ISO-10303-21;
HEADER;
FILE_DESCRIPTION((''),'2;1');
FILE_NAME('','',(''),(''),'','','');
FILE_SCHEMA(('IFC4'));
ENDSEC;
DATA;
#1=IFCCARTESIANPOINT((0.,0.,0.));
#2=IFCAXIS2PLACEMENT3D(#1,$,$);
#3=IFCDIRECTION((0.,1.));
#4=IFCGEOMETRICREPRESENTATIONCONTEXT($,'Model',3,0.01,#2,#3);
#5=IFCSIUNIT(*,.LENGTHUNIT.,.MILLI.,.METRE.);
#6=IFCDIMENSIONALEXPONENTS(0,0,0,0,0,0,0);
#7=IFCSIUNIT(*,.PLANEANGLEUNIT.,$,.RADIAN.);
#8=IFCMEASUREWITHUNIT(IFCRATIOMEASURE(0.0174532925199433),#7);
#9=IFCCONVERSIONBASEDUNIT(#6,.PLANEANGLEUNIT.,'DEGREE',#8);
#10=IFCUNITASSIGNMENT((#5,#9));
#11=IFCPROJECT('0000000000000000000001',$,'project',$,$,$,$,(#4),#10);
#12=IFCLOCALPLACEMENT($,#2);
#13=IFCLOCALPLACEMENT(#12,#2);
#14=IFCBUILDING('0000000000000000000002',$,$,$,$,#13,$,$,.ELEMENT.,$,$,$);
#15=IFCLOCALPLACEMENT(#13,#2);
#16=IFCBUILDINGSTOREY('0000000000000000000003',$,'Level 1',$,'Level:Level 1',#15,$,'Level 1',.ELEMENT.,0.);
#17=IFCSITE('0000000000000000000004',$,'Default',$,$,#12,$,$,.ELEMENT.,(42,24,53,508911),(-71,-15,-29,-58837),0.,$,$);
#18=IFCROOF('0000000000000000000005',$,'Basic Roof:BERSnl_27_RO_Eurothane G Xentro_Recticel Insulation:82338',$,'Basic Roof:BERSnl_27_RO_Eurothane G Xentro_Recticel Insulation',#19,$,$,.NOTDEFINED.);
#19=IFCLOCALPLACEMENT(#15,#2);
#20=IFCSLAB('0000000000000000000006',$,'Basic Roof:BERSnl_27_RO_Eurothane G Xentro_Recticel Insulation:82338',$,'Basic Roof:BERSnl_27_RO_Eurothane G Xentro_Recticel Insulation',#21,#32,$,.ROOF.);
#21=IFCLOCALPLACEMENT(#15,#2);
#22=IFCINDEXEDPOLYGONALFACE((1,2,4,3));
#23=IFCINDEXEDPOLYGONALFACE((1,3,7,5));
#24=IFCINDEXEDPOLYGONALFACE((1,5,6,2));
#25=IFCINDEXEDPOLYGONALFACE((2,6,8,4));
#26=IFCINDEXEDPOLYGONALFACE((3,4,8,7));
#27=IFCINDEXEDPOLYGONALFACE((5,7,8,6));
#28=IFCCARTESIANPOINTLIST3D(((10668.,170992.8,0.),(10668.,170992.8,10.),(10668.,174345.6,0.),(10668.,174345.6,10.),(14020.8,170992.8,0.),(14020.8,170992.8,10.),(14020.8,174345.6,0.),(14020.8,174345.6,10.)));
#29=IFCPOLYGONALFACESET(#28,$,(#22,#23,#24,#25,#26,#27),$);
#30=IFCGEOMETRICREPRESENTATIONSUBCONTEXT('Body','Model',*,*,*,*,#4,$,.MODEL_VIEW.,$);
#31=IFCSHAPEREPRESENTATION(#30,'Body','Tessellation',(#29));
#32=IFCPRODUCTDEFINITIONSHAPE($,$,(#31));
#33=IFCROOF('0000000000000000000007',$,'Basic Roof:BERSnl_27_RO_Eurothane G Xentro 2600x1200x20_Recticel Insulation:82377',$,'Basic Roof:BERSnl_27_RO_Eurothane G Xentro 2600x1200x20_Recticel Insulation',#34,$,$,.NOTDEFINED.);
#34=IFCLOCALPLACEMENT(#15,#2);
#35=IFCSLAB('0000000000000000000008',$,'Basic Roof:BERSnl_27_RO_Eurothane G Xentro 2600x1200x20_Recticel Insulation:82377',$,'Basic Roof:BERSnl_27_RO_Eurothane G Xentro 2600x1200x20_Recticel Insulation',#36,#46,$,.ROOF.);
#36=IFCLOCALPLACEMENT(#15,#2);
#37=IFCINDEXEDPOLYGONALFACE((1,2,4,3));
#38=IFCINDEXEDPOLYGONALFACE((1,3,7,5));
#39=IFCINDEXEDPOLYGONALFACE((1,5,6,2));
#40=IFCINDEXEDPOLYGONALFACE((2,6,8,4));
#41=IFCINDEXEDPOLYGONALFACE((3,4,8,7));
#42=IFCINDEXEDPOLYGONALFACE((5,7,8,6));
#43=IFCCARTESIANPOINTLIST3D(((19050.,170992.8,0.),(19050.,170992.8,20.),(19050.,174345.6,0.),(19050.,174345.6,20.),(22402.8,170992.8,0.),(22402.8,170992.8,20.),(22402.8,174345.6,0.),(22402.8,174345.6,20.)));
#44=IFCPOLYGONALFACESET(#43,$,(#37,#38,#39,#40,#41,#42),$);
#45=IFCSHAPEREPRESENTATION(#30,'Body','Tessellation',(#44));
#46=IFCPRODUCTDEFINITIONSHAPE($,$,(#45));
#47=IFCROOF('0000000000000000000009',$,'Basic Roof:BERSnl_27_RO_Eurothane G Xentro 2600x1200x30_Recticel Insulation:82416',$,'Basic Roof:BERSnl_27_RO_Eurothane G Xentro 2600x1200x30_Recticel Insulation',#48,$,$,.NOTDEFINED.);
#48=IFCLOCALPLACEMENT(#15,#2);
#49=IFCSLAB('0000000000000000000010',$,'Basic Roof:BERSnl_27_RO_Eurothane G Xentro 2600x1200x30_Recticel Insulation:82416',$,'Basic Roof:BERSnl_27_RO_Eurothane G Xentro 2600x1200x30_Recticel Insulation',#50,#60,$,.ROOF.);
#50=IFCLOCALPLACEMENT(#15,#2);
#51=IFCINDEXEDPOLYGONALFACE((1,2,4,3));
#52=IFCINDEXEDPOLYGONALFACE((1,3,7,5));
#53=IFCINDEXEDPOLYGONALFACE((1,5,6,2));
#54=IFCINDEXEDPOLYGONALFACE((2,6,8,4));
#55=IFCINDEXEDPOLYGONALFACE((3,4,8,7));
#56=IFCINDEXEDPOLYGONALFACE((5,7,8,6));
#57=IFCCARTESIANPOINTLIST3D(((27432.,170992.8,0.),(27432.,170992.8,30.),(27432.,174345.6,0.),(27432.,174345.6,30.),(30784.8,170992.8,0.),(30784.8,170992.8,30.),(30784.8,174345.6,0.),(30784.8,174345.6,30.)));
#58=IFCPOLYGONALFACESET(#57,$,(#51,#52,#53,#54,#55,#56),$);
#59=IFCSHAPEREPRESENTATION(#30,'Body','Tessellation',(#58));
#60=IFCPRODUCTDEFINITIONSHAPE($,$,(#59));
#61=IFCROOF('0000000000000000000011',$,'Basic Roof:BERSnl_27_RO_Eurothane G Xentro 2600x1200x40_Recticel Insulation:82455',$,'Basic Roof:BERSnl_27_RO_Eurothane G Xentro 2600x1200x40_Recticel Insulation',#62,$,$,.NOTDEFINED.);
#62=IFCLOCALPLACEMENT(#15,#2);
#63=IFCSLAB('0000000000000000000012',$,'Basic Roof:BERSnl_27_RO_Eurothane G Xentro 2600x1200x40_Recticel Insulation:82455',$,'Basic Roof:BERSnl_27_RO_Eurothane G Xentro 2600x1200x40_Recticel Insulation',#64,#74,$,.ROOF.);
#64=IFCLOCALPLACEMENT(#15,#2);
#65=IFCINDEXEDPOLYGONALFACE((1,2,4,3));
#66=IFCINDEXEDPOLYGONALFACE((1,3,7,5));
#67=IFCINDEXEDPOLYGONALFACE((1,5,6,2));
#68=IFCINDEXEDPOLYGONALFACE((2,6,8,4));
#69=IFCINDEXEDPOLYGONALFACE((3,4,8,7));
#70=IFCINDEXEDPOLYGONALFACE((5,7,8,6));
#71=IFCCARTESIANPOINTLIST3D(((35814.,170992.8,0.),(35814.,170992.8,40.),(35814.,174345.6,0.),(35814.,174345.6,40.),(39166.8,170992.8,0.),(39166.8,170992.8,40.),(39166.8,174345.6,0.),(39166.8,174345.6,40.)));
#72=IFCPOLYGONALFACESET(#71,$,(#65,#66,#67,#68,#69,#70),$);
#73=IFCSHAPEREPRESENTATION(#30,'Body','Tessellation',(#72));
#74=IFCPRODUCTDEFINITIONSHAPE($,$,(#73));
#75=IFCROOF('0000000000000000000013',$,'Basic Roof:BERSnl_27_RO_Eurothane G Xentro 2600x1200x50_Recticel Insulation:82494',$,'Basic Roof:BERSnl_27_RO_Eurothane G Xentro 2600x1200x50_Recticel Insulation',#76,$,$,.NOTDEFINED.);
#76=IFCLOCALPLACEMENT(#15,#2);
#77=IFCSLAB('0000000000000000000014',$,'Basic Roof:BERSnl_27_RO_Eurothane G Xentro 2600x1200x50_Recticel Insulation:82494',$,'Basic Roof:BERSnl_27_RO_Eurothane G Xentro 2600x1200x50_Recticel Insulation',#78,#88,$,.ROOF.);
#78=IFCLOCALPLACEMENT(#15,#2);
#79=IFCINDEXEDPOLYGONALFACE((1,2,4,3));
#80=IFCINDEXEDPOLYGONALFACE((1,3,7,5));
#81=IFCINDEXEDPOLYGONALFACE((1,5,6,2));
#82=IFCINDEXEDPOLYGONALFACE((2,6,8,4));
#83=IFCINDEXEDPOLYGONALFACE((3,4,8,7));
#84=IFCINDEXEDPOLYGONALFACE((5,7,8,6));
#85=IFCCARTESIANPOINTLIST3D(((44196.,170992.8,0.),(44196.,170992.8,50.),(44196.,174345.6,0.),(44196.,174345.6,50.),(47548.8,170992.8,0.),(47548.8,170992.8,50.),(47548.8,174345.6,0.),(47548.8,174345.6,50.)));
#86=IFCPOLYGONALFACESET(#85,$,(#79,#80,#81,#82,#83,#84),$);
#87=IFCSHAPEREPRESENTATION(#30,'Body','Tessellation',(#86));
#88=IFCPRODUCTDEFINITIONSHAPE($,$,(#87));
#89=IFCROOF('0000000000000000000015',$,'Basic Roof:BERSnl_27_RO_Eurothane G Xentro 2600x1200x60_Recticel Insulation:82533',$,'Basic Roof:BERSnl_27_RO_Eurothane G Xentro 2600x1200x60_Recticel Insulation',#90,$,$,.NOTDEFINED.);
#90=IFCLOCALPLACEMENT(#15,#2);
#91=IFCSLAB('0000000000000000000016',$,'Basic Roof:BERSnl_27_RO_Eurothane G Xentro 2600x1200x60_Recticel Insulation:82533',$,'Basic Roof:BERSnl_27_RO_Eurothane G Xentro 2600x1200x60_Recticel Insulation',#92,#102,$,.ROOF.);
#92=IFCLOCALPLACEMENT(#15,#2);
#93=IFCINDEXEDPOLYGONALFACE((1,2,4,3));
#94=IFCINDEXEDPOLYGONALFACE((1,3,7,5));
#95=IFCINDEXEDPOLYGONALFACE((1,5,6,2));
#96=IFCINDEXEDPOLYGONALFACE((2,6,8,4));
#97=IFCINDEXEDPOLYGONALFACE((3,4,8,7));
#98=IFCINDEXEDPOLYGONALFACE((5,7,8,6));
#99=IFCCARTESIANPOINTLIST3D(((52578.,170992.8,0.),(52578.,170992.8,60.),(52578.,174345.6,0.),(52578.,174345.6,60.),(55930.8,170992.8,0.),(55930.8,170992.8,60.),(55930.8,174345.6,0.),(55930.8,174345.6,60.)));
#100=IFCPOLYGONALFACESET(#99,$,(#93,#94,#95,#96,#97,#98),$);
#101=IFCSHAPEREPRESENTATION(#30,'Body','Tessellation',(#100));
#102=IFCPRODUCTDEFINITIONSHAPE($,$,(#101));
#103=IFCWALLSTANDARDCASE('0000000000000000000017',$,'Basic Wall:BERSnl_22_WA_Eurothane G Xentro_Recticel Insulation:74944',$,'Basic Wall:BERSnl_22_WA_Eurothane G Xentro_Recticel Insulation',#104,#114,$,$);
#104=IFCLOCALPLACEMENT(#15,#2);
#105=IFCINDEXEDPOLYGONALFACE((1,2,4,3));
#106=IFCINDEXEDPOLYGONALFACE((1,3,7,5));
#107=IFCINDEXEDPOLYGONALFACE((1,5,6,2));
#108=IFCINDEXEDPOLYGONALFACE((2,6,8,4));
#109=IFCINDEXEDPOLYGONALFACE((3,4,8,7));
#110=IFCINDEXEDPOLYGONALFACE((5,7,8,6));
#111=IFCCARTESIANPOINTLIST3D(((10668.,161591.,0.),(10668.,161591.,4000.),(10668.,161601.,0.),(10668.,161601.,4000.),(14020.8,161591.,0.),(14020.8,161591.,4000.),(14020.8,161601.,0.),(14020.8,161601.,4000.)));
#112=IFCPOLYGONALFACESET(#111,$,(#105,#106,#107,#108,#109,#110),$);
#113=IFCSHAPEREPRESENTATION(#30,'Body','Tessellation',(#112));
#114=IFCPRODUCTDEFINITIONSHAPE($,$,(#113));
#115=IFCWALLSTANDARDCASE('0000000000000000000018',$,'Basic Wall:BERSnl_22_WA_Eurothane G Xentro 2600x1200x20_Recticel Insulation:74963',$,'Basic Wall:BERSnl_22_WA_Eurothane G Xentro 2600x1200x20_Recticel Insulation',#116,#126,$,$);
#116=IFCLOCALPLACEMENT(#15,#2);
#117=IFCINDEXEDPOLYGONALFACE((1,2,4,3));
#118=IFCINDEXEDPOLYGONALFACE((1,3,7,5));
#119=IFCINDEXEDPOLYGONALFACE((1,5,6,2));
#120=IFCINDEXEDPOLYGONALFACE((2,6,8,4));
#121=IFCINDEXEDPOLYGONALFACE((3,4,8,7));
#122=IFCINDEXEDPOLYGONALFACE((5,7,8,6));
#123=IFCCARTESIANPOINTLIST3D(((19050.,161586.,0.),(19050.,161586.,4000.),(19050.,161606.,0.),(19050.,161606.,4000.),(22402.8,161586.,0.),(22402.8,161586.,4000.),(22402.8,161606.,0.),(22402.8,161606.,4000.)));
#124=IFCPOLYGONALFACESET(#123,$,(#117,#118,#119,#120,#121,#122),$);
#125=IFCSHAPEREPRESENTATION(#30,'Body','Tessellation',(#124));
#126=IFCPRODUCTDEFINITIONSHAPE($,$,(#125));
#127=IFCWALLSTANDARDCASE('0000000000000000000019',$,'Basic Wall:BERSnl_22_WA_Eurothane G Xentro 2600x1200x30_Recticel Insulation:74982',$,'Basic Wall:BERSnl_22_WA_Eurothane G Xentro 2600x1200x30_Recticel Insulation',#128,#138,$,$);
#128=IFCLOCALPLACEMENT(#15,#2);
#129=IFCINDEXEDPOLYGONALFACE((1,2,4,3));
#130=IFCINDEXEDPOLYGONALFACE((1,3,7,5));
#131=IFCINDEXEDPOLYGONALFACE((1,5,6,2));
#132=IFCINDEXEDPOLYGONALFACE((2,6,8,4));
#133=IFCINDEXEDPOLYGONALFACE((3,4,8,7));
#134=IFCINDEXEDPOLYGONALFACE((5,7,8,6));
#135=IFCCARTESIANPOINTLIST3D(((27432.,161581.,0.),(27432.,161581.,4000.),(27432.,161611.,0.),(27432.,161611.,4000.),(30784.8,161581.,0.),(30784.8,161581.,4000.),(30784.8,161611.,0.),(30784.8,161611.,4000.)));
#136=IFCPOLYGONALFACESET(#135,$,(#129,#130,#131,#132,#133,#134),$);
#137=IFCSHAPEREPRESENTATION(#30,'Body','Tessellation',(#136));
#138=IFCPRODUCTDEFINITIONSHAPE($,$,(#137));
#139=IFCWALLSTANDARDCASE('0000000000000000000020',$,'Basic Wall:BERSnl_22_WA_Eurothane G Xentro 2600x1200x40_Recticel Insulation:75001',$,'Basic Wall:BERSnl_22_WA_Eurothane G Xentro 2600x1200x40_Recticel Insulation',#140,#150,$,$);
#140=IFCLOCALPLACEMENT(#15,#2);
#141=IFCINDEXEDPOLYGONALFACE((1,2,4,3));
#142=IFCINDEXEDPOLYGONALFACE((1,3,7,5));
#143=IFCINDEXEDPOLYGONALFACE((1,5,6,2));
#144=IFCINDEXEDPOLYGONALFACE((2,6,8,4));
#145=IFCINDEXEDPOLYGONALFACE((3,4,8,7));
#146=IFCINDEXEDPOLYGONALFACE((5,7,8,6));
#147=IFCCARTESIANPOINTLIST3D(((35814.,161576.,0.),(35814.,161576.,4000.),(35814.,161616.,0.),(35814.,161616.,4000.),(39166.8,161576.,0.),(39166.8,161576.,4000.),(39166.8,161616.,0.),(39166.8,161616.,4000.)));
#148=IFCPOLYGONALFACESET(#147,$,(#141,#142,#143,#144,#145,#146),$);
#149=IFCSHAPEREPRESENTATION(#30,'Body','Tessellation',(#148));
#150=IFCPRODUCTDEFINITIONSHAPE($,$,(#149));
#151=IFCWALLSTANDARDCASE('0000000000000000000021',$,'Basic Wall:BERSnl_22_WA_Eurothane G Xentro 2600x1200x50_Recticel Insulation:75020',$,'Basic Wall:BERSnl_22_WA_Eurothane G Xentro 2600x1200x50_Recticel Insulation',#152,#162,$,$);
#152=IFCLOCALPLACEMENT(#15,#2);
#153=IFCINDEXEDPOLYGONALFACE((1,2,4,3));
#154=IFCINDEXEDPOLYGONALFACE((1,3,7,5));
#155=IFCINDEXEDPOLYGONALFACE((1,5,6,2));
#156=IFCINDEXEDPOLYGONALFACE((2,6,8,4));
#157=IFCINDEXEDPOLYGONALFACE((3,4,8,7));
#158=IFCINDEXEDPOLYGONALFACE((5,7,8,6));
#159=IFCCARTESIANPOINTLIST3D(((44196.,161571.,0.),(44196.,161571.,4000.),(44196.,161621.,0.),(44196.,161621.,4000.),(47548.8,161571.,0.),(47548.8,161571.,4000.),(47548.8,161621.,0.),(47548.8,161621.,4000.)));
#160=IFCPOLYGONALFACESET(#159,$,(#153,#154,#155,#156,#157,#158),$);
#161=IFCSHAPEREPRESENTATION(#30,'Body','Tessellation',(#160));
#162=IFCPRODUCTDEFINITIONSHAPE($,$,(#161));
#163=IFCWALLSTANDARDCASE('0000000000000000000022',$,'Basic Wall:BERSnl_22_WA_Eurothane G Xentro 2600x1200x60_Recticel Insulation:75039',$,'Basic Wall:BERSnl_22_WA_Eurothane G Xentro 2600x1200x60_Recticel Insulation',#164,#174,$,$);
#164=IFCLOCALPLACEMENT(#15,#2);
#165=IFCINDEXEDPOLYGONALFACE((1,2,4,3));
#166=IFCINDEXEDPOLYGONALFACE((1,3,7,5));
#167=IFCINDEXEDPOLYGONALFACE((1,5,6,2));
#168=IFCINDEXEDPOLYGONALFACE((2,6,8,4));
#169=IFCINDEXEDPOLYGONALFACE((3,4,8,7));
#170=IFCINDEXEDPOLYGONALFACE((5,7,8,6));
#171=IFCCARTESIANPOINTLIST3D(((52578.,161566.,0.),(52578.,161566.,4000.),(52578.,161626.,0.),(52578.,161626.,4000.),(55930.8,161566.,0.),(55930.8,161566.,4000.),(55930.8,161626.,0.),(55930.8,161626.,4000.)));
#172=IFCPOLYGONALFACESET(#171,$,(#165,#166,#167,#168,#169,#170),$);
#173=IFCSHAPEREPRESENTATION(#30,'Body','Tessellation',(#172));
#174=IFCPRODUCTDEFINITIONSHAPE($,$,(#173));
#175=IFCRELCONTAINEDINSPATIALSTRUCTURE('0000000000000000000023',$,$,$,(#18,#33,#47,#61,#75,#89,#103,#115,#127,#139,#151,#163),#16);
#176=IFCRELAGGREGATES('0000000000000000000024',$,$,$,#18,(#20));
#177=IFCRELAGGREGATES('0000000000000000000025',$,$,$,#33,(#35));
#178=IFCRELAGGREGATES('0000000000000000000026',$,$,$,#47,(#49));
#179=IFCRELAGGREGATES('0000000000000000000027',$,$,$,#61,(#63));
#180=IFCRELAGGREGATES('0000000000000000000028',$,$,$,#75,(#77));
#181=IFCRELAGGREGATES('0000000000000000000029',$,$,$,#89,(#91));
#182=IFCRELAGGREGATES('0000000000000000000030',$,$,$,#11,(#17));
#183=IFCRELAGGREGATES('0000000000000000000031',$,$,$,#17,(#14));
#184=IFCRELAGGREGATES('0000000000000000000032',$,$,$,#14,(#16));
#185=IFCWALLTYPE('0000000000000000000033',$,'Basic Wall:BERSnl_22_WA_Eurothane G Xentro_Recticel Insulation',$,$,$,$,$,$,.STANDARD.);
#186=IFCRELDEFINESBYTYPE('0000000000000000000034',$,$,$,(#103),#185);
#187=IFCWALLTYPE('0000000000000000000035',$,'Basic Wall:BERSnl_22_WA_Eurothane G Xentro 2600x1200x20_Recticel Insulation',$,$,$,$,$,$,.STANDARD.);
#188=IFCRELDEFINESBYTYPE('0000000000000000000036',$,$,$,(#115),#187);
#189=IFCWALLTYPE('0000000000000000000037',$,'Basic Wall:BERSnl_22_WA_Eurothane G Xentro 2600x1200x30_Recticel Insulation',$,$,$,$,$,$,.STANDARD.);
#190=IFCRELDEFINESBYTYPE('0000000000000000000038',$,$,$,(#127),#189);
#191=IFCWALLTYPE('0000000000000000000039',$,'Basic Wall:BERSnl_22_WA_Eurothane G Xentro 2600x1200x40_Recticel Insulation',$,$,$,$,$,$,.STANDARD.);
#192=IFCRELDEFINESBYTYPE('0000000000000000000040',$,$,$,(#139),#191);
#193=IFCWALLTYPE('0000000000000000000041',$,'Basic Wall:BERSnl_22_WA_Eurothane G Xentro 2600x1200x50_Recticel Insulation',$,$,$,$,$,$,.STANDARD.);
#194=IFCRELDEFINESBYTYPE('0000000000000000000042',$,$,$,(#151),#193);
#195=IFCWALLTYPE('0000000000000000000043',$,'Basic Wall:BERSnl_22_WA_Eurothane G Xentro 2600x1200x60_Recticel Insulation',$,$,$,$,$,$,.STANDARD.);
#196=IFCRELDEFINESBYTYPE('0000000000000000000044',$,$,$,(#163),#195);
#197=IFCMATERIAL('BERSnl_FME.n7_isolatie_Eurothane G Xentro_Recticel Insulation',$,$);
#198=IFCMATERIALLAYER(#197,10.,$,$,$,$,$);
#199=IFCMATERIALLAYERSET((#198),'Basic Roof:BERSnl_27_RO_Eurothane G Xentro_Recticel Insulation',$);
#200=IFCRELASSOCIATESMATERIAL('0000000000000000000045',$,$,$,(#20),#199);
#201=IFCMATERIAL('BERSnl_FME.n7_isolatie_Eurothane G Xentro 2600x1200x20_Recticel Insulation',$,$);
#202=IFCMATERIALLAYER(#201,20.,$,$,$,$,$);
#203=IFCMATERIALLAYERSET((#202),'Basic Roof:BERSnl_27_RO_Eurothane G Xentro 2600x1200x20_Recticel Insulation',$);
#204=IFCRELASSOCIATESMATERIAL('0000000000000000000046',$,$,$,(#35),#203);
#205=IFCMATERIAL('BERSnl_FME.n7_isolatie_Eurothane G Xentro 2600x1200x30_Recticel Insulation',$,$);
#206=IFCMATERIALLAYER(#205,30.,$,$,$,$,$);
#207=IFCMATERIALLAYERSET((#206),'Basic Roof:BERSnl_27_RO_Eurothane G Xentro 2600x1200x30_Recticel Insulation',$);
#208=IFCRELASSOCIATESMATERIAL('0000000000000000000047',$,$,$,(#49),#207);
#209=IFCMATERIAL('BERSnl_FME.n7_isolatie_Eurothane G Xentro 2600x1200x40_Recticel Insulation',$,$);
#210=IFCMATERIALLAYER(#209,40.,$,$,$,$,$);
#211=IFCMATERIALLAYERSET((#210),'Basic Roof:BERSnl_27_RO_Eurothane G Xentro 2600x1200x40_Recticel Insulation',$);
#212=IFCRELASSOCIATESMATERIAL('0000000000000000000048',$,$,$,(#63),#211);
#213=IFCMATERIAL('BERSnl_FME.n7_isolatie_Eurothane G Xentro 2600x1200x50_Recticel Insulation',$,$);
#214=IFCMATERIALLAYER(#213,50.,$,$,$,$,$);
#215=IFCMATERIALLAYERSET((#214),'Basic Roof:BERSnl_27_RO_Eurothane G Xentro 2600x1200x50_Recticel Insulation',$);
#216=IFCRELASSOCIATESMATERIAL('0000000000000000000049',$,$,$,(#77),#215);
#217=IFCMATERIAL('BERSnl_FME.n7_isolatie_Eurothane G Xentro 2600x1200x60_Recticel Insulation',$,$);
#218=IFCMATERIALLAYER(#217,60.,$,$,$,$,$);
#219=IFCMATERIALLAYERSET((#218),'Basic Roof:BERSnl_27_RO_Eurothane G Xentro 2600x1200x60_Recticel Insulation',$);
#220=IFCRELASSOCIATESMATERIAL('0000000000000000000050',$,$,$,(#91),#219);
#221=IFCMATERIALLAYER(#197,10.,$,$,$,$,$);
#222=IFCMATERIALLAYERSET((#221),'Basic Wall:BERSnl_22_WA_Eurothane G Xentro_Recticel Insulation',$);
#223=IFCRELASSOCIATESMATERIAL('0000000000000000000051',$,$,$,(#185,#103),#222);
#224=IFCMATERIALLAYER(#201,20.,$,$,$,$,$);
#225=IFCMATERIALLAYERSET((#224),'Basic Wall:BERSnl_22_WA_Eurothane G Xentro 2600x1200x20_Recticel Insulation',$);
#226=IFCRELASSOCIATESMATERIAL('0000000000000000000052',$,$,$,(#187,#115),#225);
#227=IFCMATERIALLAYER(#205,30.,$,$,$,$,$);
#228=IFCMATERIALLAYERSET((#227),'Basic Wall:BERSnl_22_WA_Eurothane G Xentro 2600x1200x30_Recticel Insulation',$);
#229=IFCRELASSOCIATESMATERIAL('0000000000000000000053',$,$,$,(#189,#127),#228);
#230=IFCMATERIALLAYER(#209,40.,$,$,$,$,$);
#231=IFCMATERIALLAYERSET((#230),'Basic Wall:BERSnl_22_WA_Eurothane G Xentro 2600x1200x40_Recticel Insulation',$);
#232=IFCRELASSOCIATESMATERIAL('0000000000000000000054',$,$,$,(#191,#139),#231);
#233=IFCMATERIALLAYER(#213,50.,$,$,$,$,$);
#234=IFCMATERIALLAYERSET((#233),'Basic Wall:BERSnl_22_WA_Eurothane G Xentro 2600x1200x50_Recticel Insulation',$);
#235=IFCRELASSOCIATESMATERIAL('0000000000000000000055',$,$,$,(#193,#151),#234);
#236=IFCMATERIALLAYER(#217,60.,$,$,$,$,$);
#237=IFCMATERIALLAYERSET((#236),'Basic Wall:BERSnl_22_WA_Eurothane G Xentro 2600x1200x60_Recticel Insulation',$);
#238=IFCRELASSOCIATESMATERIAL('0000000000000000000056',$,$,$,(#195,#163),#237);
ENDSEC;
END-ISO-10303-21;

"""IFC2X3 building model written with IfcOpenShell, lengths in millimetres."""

from ifc_helpers import new_model, entity, si_unit, converted_unit, direction, frame, frame_2d, origin, place, context, subcontext, project, spatial, rectangle, extrude, material, layer, layer_set, layer_usage, type_object, element, aggregate, save


model = new_model("IFC2X3")

# Units and contexts
model_context = context("Model", 3, precision=0.01, world=origin(), true_north=direction((0.0, 1.0)))
body_context = subcontext(model_context, "Body", "Model", "MODEL_VIEW")
ifc_project = project(units=[si_unit("LENGTHUNIT", "METRE", prefix="MILLI"), converted_unit("PLANEANGLEUNIT", "DEGREE", entity("IfcRatioMeasure", 0.0174532925199433), si_unit("PLANEANGLEUNIT", "RADIAN"), dimensions=[0, 0, 0, 0, 0, 0, 0])], contexts=[model_context])

# Site, building, storey
site_placement = place(None, origin())
site = spatial("IfcSite", under=ifc_project, at=site_placement, Name="Default", CompositionType="ELEMENT", RefLatitude=(42, 24, 53, 508911), RefLongitude=(-71, -15, -29, -58837), RefElevation=0.0)
building_placement = place(site_placement, origin())
building = spatial("IfcBuilding", under=site, at=building_placement, CompositionType="ELEMENT")
storey_placement = place(building_placement, origin())
storey = spatial("IfcBuildingStorey", under=building, at=storey_placement, Name="Level 1", ObjectType="Level:Level 1", LongName="Level 1", CompositionType="ELEMENT", Elevation=0.0)

# Roofs, slabs
roof_1_placement = place(storey_placement, frame((10668.0, 170992.8, 0.0)))
roof_1 = element("IfcRoof", 1, at=roof_1_placement, inside=storey, Name="Basic Roof:BERSnl_27_RO_Eurothane G Xentro_Recticel Insulation:82338", ObjectType="Basic Roof:BERSnl_27_RO_Eurothane G Xentro_Recticel Insulation", ShapeType="NOTDEFINED")
ifc_material_1 = material(Name="BERSnl_FME.n7_isolatie_Eurothane G Xentro_Recticel Insulation")
ifc_layer_1 = layer(ifc_material_1, 10.0)
ifc_layer_set_1 = layer_set([ifc_layer_1], Name="Basic Roof:BERSnl_27_RO_Eurothane G Xentro_Recticel Insulation")
slab_1_placement = place(roof_1_placement, origin())
slab_1 = element("IfcSlab", 2, at=slab_1_placement, material=ifc_layer_set_1, Name="Basic Roof:BERSnl_27_RO_Eurothane G Xentro_Recticel Insulation:82338", ObjectType="Basic Roof:BERSnl_27_RO_Eurothane G Xentro_Recticel Insulation", PredefinedType="ROOF", context=body_context, shape_type="SweptSolid", body=[
    extrude(rectangle(XDim=3352.8, YDim=3352.8, at=frame_2d((0.0, 0.0), x_axis=(-1.0, 0.0))), frame((1676.4, 1676.4, 0.0)), (0.0, 0.0, 1.0), 10.0),
])
aggregate(roof_1, [slab_1])
roof_2_placement = place(storey_placement, frame((19050.0, 170992.8, 0.0)))
roof_2 = element("IfcRoof", 3, at=roof_2_placement, inside=storey, Name="Basic Roof:BERSnl_27_RO_Eurothane G Xentro 2600x1200x20_Recticel Insulation:82377", ObjectType="Basic Roof:BERSnl_27_RO_Eurothane G Xentro 2600x1200x20_Recticel Insulation", ShapeType="NOTDEFINED")
ifc_material_2 = material(Name="BERSnl_FME.n7_isolatie_Eurothane G Xentro 2600x1200x20_Recticel Insulation")
ifc_layer_2 = layer(ifc_material_2, 20.0)
ifc_layer_set_2 = layer_set([ifc_layer_2], Name="Basic Roof:BERSnl_27_RO_Eurothane G Xentro 2600x1200x20_Recticel Insulation")
slab_2_placement = place(roof_2_placement, origin())
slab_2 = element("IfcSlab", 4, at=slab_2_placement, material=ifc_layer_set_2, Name="Basic Roof:BERSnl_27_RO_Eurothane G Xentro 2600x1200x20_Recticel Insulation:82377", ObjectType="Basic Roof:BERSnl_27_RO_Eurothane G Xentro 2600x1200x20_Recticel Insulation", PredefinedType="ROOF", context=body_context, shape_type="SweptSolid", body=[
    extrude(rectangle(XDim=3352.8, YDim=3352.8, at=frame_2d((0.0, 0.0), x_axis=(-1.0, 0.0))), frame((1676.4, 1676.4, 0.0)), (0.0, 0.0, 1.0), 20.0),
])
aggregate(roof_2, [slab_2])
roof_3_placement = place(storey_placement, frame((27432.0, 170992.8, 0.0)))
roof_3 = element("IfcRoof", 5, at=roof_3_placement, inside=storey, Name="Basic Roof:BERSnl_27_RO_Eurothane G Xentro 2600x1200x30_Recticel Insulation:82416", ObjectType="Basic Roof:BERSnl_27_RO_Eurothane G Xentro 2600x1200x30_Recticel Insulation", ShapeType="NOTDEFINED")
ifc_material_3 = material(Name="BERSnl_FME.n7_isolatie_Eurothane G Xentro 2600x1200x30_Recticel Insulation")
ifc_layer_3 = layer(ifc_material_3, 30.0)
ifc_layer_set_3 = layer_set([ifc_layer_3], Name="Basic Roof:BERSnl_27_RO_Eurothane G Xentro 2600x1200x30_Recticel Insulation")
slab_3_placement = place(roof_3_placement, origin())
slab_3 = element("IfcSlab", 6, at=slab_3_placement, material=ifc_layer_set_3, Name="Basic Roof:BERSnl_27_RO_Eurothane G Xentro 2600x1200x30_Recticel Insulation:82416", ObjectType="Basic Roof:BERSnl_27_RO_Eurothane G Xentro 2600x1200x30_Recticel Insulation", PredefinedType="ROOF", context=body_context, shape_type="SweptSolid", body=[
    extrude(rectangle(XDim=3352.8, YDim=3352.8, at=frame_2d((0.0, 0.0), x_axis=(-1.0, 0.0))), frame((1676.4, 1676.4, 0.0)), (0.0, 0.0, 1.0), 30.0),
])
aggregate(roof_3, [slab_3])
roof_4_placement = place(storey_placement, frame((35814.0, 170992.8, 0.0)))
roof_4 = element("IfcRoof", 7, at=roof_4_placement, inside=storey, Name="Basic Roof:BERSnl_27_RO_Eurothane G Xentro 2600x1200x40_Recticel Insulation:82455", ObjectType="Basic Roof:BERSnl_27_RO_Eurothane G Xentro 2600x1200x40_Recticel Insulation", ShapeType="NOTDEFINED")
ifc_material_4 = material(Name="BERSnl_FME.n7_isolatie_Eurothane G Xentro 2600x1200x40_Recticel Insulation")
ifc_layer_4 = layer(ifc_material_4, 40.0)
ifc_layer_set_4 = layer_set([ifc_layer_4], Name="Basic Roof:BERSnl_27_RO_Eurothane G Xentro 2600x1200x40_Recticel Insulation")
slab_4_placement = place(roof_4_placement, origin())
slab_4 = element("IfcSlab", 8, at=slab_4_placement, material=ifc_layer_set_4, Name="Basic Roof:BERSnl_27_RO_Eurothane G Xentro 2600x1200x40_Recticel Insulation:82455", ObjectType="Basic Roof:BERSnl_27_RO_Eurothane G Xentro 2600x1200x40_Recticel Insulation", PredefinedType="ROOF", context=body_context, shape_type="SweptSolid", body=[
    extrude(rectangle(XDim=3352.8, YDim=3352.8, at=frame_2d((0.0, 0.0), x_axis=(-1.0, 0.0))), frame((1676.4, 1676.4, 0.0)), (0.0, 0.0, 1.0), 40.0),
])
aggregate(roof_4, [slab_4])
roof_5_placement = place(storey_placement, frame((44196.0, 170992.8, 0.0)))
roof_5 = element("IfcRoof", 9, at=roof_5_placement, inside=storey, Name="Basic Roof:BERSnl_27_RO_Eurothane G Xentro 2600x1200x50_Recticel Insulation:82494", ObjectType="Basic Roof:BERSnl_27_RO_Eurothane G Xentro 2600x1200x50_Recticel Insulation", ShapeType="NOTDEFINED")
ifc_material_5 = material(Name="BERSnl_FME.n7_isolatie_Eurothane G Xentro 2600x1200x50_Recticel Insulation")
ifc_layer_5 = layer(ifc_material_5, 50.0)
ifc_layer_set_5 = layer_set([ifc_layer_5], Name="Basic Roof:BERSnl_27_RO_Eurothane G Xentro 2600x1200x50_Recticel Insulation")
slab_5_placement = place(roof_5_placement, origin())
slab_5 = element("IfcSlab", 10, at=slab_5_placement, material=ifc_layer_set_5, Name="Basic Roof:BERSnl_27_RO_Eurothane G Xentro 2600x1200x50_Recticel Insulation:82494", ObjectType="Basic Roof:BERSnl_27_RO_Eurothane G Xentro 2600x1200x50_Recticel Insulation", PredefinedType="ROOF", context=body_context, shape_type="SweptSolid", body=[
    extrude(rectangle(XDim=3352.8, YDim=3352.8, at=frame_2d((0.0, 0.0), x_axis=(-1.0, 0.0))), frame((1676.4, 1676.4, 0.0)), (0.0, 0.0, 1.0), 50.0),
])
aggregate(roof_5, [slab_5])
roof_6_placement = place(storey_placement, frame((52578.0, 170992.8, 0.0)))
roof_6 = element("IfcRoof", 11, at=roof_6_placement, inside=storey, Name="Basic Roof:BERSnl_27_RO_Eurothane G Xentro 2600x1200x60_Recticel Insulation:82533", ObjectType="Basic Roof:BERSnl_27_RO_Eurothane G Xentro 2600x1200x60_Recticel Insulation", ShapeType="NOTDEFINED")
ifc_material_6 = material(Name="BERSnl_FME.n7_isolatie_Eurothane G Xentro 2600x1200x60_Recticel Insulation")
ifc_layer_6 = layer(ifc_material_6, 60.0)
ifc_layer_set_6 = layer_set([ifc_layer_6], Name="Basic Roof:BERSnl_27_RO_Eurothane G Xentro 2600x1200x60_Recticel Insulation")
slab_6_placement = place(roof_6_placement, origin())
slab_6 = element("IfcSlab", 12, at=slab_6_placement, material=ifc_layer_set_6, Name="Basic Roof:BERSnl_27_RO_Eurothane G Xentro 2600x1200x60_Recticel Insulation:82533", ObjectType="Basic Roof:BERSnl_27_RO_Eurothane G Xentro 2600x1200x60_Recticel Insulation", PredefinedType="ROOF", context=body_context, shape_type="SweptSolid", body=[
    extrude(rectangle(XDim=3352.8, YDim=3352.8, at=frame_2d((0.0, 0.0), x_axis=(-1.0, 0.0))), frame((1676.4, 1676.4, 0.0)), (0.0, 0.0, 1.0), 60.0),
])
aggregate(roof_6, [slab_6])

# Walls
ifc_layer_7 = layer(ifc_material_1, 10.0)
ifc_layer_set_7 = layer_set([ifc_layer_7], Name="Basic Wall:BERSnl_22_WA_Eurothane G Xentro_Recticel Insulation")
ifc_layer_usage_1 = layer_usage(ifc_layer_set_7, "AXIS2", "NEGATIVE", 5.0)
wall_type_1 = type_object("IfcWallType", Name="Basic Wall:BERSnl_22_WA_Eurothane G Xentro_Recticel Insulation", PredefinedType="STANDARD", material=ifc_layer_set_7)
wall_1_placement = place(storey_placement, frame((10668.0, 161596.0, 0.0)))
element("IfcWallStandardCase", 13, at=wall_1_placement, inside=storey, type_object=wall_type_1, material=ifc_layer_usage_1, Name="Basic Wall:BERSnl_22_WA_Eurothane G Xentro_Recticel Insulation:74944", ObjectType="Basic Wall:BERSnl_22_WA_Eurothane G Xentro_Recticel Insulation", context=body_context, shape_type="SweptSolid", body=[
    extrude(rectangle(XDim=3352.8, YDim=10.0, at=frame_2d((1676.4, 0.0), x_axis=(-1.0, 0.0))), origin(), (0.0, 0.0, 1.0), 4000.0),
])
ifc_layer_8 = layer(ifc_material_2, 20.0)
ifc_layer_set_8 = layer_set([ifc_layer_8], Name="Basic Wall:BERSnl_22_WA_Eurothane G Xentro 2600x1200x20_Recticel Insulation")
ifc_layer_usage_2 = layer_usage(ifc_layer_set_8, "AXIS2", "NEGATIVE", 10.0)
wall_type_2 = type_object("IfcWallType", Name="Basic Wall:BERSnl_22_WA_Eurothane G Xentro 2600x1200x20_Recticel Insulation", PredefinedType="STANDARD", material=ifc_layer_set_8)
wall_2_placement = place(storey_placement, frame((19050.0, 161596.0, 0.0)))
element("IfcWallStandardCase", 14, at=wall_2_placement, inside=storey, type_object=wall_type_2, material=ifc_layer_usage_2, Name="Basic Wall:BERSnl_22_WA_Eurothane G Xentro 2600x1200x20_Recticel Insulation:74963", ObjectType="Basic Wall:BERSnl_22_WA_Eurothane G Xentro 2600x1200x20_Recticel Insulation", context=body_context, shape_type="SweptSolid", body=[
    extrude(rectangle(XDim=3352.8, YDim=20.0, at=frame_2d((1676.4, 0.0), x_axis=(-1.0, 0.0))), origin(), (0.0, 0.0, 1.0), 4000.0),
])
ifc_layer_9 = layer(ifc_material_3, 30.0)
ifc_layer_set_9 = layer_set([ifc_layer_9], Name="Basic Wall:BERSnl_22_WA_Eurothane G Xentro 2600x1200x30_Recticel Insulation")
ifc_layer_usage_3 = layer_usage(ifc_layer_set_9, "AXIS2", "NEGATIVE", 15.0)
wall_type_3 = type_object("IfcWallType", Name="Basic Wall:BERSnl_22_WA_Eurothane G Xentro 2600x1200x30_Recticel Insulation", PredefinedType="STANDARD", material=ifc_layer_set_9)
wall_3_placement = place(storey_placement, frame((27432.0, 161596.0, 0.0)))
element("IfcWallStandardCase", 15, at=wall_3_placement, inside=storey, type_object=wall_type_3, material=ifc_layer_usage_3, Name="Basic Wall:BERSnl_22_WA_Eurothane G Xentro 2600x1200x30_Recticel Insulation:74982", ObjectType="Basic Wall:BERSnl_22_WA_Eurothane G Xentro 2600x1200x30_Recticel Insulation", context=body_context, shape_type="SweptSolid", body=[
    extrude(rectangle(XDim=3352.8, YDim=30.0, at=frame_2d((1676.4, 0.0), x_axis=(-1.0, 0.0))), origin(), (0.0, 0.0, 1.0), 4000.0),
])
ifc_layer_10 = layer(ifc_material_4, 40.0)
ifc_layer_set_10 = layer_set([ifc_layer_10], Name="Basic Wall:BERSnl_22_WA_Eurothane G Xentro 2600x1200x40_Recticel Insulation")
ifc_layer_usage_4 = layer_usage(ifc_layer_set_10, "AXIS2", "NEGATIVE", 20.0)
wall_type_4 = type_object("IfcWallType", Name="Basic Wall:BERSnl_22_WA_Eurothane G Xentro 2600x1200x40_Recticel Insulation", PredefinedType="STANDARD", material=ifc_layer_set_10)
wall_4_placement = place(storey_placement, frame((35814.0, 161596.0, 0.0)))
element("IfcWallStandardCase", 16, at=wall_4_placement, inside=storey, type_object=wall_type_4, material=ifc_layer_usage_4, Name="Basic Wall:BERSnl_22_WA_Eurothane G Xentro 2600x1200x40_Recticel Insulation:75001", ObjectType="Basic Wall:BERSnl_22_WA_Eurothane G Xentro 2600x1200x40_Recticel Insulation", context=body_context, shape_type="SweptSolid", body=[
    extrude(rectangle(XDim=3352.8, YDim=40.0, at=frame_2d((1676.4, 0.0), x_axis=(-1.0, 0.0))), origin(), (0.0, 0.0, 1.0), 4000.0),
])
ifc_layer_11 = layer(ifc_material_5, 50.0)
ifc_layer_set_11 = layer_set([ifc_layer_11], Name="Basic Wall:BERSnl_22_WA_Eurothane G Xentro 2600x1200x50_Recticel Insulation")
ifc_layer_usage_5 = layer_usage(ifc_layer_set_11, "AXIS2", "NEGATIVE", 25.0)
wall_type_5 = type_object("IfcWallType", Name="Basic Wall:BERSnl_22_WA_Eurothane G Xentro 2600x1200x50_Recticel Insulation", PredefinedType="STANDARD", material=ifc_layer_set_11)
wall_5_placement = place(storey_placement, frame((44196.0, 161596.0, 0.0)))
element("IfcWallStandardCase", 17, at=wall_5_placement, inside=storey, type_object=wall_type_5, material=ifc_layer_usage_5, Name="Basic Wall:BERSnl_22_WA_Eurothane G Xentro 2600x1200x50_Recticel Insulation:75020", ObjectType="Basic Wall:BERSnl_22_WA_Eurothane G Xentro 2600x1200x50_Recticel Insulation", context=body_context, shape_type="SweptSolid", body=[
    extrude(rectangle(XDim=3352.8, YDim=50.0, at=frame_2d((1676.4, 0.0), x_axis=(-1.0, 0.0))), origin(), (0.0, 0.0, 1.0), 4000.0),
])
ifc_layer_12 = layer(ifc_material_6, 60.0)
ifc_layer_set_12 = layer_set([ifc_layer_12], Name="Basic Wall:BERSnl_22_WA_Eurothane G Xentro 2600x1200x60_Recticel Insulation")
ifc_layer_usage_6 = layer_usage(ifc_layer_set_12, "AXIS2", "NEGATIVE", 30.0)
wall_type_6 = type_object("IfcWallType", Name="Basic Wall:BERSnl_22_WA_Eurothane G Xentro 2600x1200x60_Recticel Insulation", PredefinedType="STANDARD", material=ifc_layer_set_12)
wall_6_placement = place(storey_placement, frame((52578.0, 161596.0, 0.0)))
element("IfcWallStandardCase", 18, at=wall_6_placement, inside=storey, type_object=wall_type_6, material=ifc_layer_usage_6, Name="Basic Wall:BERSnl_22_WA_Eurothane G Xentro 2600x1200x60_Recticel Insulation:75039", ObjectType="Basic Wall:BERSnl_22_WA_Eurothane G Xentro 2600x1200x60_Recticel Insulation", context=body_context, shape_type="SweptSolid", body=[
    extrude(rectangle(XDim=3352.8, YDim=60.0, at=frame_2d((1676.4, 0.0), x_axis=(-1.0, 0.0))), origin(), (0.0, 0.0, 1.0), 4000.0),
])

save(model, "model.ifc")
